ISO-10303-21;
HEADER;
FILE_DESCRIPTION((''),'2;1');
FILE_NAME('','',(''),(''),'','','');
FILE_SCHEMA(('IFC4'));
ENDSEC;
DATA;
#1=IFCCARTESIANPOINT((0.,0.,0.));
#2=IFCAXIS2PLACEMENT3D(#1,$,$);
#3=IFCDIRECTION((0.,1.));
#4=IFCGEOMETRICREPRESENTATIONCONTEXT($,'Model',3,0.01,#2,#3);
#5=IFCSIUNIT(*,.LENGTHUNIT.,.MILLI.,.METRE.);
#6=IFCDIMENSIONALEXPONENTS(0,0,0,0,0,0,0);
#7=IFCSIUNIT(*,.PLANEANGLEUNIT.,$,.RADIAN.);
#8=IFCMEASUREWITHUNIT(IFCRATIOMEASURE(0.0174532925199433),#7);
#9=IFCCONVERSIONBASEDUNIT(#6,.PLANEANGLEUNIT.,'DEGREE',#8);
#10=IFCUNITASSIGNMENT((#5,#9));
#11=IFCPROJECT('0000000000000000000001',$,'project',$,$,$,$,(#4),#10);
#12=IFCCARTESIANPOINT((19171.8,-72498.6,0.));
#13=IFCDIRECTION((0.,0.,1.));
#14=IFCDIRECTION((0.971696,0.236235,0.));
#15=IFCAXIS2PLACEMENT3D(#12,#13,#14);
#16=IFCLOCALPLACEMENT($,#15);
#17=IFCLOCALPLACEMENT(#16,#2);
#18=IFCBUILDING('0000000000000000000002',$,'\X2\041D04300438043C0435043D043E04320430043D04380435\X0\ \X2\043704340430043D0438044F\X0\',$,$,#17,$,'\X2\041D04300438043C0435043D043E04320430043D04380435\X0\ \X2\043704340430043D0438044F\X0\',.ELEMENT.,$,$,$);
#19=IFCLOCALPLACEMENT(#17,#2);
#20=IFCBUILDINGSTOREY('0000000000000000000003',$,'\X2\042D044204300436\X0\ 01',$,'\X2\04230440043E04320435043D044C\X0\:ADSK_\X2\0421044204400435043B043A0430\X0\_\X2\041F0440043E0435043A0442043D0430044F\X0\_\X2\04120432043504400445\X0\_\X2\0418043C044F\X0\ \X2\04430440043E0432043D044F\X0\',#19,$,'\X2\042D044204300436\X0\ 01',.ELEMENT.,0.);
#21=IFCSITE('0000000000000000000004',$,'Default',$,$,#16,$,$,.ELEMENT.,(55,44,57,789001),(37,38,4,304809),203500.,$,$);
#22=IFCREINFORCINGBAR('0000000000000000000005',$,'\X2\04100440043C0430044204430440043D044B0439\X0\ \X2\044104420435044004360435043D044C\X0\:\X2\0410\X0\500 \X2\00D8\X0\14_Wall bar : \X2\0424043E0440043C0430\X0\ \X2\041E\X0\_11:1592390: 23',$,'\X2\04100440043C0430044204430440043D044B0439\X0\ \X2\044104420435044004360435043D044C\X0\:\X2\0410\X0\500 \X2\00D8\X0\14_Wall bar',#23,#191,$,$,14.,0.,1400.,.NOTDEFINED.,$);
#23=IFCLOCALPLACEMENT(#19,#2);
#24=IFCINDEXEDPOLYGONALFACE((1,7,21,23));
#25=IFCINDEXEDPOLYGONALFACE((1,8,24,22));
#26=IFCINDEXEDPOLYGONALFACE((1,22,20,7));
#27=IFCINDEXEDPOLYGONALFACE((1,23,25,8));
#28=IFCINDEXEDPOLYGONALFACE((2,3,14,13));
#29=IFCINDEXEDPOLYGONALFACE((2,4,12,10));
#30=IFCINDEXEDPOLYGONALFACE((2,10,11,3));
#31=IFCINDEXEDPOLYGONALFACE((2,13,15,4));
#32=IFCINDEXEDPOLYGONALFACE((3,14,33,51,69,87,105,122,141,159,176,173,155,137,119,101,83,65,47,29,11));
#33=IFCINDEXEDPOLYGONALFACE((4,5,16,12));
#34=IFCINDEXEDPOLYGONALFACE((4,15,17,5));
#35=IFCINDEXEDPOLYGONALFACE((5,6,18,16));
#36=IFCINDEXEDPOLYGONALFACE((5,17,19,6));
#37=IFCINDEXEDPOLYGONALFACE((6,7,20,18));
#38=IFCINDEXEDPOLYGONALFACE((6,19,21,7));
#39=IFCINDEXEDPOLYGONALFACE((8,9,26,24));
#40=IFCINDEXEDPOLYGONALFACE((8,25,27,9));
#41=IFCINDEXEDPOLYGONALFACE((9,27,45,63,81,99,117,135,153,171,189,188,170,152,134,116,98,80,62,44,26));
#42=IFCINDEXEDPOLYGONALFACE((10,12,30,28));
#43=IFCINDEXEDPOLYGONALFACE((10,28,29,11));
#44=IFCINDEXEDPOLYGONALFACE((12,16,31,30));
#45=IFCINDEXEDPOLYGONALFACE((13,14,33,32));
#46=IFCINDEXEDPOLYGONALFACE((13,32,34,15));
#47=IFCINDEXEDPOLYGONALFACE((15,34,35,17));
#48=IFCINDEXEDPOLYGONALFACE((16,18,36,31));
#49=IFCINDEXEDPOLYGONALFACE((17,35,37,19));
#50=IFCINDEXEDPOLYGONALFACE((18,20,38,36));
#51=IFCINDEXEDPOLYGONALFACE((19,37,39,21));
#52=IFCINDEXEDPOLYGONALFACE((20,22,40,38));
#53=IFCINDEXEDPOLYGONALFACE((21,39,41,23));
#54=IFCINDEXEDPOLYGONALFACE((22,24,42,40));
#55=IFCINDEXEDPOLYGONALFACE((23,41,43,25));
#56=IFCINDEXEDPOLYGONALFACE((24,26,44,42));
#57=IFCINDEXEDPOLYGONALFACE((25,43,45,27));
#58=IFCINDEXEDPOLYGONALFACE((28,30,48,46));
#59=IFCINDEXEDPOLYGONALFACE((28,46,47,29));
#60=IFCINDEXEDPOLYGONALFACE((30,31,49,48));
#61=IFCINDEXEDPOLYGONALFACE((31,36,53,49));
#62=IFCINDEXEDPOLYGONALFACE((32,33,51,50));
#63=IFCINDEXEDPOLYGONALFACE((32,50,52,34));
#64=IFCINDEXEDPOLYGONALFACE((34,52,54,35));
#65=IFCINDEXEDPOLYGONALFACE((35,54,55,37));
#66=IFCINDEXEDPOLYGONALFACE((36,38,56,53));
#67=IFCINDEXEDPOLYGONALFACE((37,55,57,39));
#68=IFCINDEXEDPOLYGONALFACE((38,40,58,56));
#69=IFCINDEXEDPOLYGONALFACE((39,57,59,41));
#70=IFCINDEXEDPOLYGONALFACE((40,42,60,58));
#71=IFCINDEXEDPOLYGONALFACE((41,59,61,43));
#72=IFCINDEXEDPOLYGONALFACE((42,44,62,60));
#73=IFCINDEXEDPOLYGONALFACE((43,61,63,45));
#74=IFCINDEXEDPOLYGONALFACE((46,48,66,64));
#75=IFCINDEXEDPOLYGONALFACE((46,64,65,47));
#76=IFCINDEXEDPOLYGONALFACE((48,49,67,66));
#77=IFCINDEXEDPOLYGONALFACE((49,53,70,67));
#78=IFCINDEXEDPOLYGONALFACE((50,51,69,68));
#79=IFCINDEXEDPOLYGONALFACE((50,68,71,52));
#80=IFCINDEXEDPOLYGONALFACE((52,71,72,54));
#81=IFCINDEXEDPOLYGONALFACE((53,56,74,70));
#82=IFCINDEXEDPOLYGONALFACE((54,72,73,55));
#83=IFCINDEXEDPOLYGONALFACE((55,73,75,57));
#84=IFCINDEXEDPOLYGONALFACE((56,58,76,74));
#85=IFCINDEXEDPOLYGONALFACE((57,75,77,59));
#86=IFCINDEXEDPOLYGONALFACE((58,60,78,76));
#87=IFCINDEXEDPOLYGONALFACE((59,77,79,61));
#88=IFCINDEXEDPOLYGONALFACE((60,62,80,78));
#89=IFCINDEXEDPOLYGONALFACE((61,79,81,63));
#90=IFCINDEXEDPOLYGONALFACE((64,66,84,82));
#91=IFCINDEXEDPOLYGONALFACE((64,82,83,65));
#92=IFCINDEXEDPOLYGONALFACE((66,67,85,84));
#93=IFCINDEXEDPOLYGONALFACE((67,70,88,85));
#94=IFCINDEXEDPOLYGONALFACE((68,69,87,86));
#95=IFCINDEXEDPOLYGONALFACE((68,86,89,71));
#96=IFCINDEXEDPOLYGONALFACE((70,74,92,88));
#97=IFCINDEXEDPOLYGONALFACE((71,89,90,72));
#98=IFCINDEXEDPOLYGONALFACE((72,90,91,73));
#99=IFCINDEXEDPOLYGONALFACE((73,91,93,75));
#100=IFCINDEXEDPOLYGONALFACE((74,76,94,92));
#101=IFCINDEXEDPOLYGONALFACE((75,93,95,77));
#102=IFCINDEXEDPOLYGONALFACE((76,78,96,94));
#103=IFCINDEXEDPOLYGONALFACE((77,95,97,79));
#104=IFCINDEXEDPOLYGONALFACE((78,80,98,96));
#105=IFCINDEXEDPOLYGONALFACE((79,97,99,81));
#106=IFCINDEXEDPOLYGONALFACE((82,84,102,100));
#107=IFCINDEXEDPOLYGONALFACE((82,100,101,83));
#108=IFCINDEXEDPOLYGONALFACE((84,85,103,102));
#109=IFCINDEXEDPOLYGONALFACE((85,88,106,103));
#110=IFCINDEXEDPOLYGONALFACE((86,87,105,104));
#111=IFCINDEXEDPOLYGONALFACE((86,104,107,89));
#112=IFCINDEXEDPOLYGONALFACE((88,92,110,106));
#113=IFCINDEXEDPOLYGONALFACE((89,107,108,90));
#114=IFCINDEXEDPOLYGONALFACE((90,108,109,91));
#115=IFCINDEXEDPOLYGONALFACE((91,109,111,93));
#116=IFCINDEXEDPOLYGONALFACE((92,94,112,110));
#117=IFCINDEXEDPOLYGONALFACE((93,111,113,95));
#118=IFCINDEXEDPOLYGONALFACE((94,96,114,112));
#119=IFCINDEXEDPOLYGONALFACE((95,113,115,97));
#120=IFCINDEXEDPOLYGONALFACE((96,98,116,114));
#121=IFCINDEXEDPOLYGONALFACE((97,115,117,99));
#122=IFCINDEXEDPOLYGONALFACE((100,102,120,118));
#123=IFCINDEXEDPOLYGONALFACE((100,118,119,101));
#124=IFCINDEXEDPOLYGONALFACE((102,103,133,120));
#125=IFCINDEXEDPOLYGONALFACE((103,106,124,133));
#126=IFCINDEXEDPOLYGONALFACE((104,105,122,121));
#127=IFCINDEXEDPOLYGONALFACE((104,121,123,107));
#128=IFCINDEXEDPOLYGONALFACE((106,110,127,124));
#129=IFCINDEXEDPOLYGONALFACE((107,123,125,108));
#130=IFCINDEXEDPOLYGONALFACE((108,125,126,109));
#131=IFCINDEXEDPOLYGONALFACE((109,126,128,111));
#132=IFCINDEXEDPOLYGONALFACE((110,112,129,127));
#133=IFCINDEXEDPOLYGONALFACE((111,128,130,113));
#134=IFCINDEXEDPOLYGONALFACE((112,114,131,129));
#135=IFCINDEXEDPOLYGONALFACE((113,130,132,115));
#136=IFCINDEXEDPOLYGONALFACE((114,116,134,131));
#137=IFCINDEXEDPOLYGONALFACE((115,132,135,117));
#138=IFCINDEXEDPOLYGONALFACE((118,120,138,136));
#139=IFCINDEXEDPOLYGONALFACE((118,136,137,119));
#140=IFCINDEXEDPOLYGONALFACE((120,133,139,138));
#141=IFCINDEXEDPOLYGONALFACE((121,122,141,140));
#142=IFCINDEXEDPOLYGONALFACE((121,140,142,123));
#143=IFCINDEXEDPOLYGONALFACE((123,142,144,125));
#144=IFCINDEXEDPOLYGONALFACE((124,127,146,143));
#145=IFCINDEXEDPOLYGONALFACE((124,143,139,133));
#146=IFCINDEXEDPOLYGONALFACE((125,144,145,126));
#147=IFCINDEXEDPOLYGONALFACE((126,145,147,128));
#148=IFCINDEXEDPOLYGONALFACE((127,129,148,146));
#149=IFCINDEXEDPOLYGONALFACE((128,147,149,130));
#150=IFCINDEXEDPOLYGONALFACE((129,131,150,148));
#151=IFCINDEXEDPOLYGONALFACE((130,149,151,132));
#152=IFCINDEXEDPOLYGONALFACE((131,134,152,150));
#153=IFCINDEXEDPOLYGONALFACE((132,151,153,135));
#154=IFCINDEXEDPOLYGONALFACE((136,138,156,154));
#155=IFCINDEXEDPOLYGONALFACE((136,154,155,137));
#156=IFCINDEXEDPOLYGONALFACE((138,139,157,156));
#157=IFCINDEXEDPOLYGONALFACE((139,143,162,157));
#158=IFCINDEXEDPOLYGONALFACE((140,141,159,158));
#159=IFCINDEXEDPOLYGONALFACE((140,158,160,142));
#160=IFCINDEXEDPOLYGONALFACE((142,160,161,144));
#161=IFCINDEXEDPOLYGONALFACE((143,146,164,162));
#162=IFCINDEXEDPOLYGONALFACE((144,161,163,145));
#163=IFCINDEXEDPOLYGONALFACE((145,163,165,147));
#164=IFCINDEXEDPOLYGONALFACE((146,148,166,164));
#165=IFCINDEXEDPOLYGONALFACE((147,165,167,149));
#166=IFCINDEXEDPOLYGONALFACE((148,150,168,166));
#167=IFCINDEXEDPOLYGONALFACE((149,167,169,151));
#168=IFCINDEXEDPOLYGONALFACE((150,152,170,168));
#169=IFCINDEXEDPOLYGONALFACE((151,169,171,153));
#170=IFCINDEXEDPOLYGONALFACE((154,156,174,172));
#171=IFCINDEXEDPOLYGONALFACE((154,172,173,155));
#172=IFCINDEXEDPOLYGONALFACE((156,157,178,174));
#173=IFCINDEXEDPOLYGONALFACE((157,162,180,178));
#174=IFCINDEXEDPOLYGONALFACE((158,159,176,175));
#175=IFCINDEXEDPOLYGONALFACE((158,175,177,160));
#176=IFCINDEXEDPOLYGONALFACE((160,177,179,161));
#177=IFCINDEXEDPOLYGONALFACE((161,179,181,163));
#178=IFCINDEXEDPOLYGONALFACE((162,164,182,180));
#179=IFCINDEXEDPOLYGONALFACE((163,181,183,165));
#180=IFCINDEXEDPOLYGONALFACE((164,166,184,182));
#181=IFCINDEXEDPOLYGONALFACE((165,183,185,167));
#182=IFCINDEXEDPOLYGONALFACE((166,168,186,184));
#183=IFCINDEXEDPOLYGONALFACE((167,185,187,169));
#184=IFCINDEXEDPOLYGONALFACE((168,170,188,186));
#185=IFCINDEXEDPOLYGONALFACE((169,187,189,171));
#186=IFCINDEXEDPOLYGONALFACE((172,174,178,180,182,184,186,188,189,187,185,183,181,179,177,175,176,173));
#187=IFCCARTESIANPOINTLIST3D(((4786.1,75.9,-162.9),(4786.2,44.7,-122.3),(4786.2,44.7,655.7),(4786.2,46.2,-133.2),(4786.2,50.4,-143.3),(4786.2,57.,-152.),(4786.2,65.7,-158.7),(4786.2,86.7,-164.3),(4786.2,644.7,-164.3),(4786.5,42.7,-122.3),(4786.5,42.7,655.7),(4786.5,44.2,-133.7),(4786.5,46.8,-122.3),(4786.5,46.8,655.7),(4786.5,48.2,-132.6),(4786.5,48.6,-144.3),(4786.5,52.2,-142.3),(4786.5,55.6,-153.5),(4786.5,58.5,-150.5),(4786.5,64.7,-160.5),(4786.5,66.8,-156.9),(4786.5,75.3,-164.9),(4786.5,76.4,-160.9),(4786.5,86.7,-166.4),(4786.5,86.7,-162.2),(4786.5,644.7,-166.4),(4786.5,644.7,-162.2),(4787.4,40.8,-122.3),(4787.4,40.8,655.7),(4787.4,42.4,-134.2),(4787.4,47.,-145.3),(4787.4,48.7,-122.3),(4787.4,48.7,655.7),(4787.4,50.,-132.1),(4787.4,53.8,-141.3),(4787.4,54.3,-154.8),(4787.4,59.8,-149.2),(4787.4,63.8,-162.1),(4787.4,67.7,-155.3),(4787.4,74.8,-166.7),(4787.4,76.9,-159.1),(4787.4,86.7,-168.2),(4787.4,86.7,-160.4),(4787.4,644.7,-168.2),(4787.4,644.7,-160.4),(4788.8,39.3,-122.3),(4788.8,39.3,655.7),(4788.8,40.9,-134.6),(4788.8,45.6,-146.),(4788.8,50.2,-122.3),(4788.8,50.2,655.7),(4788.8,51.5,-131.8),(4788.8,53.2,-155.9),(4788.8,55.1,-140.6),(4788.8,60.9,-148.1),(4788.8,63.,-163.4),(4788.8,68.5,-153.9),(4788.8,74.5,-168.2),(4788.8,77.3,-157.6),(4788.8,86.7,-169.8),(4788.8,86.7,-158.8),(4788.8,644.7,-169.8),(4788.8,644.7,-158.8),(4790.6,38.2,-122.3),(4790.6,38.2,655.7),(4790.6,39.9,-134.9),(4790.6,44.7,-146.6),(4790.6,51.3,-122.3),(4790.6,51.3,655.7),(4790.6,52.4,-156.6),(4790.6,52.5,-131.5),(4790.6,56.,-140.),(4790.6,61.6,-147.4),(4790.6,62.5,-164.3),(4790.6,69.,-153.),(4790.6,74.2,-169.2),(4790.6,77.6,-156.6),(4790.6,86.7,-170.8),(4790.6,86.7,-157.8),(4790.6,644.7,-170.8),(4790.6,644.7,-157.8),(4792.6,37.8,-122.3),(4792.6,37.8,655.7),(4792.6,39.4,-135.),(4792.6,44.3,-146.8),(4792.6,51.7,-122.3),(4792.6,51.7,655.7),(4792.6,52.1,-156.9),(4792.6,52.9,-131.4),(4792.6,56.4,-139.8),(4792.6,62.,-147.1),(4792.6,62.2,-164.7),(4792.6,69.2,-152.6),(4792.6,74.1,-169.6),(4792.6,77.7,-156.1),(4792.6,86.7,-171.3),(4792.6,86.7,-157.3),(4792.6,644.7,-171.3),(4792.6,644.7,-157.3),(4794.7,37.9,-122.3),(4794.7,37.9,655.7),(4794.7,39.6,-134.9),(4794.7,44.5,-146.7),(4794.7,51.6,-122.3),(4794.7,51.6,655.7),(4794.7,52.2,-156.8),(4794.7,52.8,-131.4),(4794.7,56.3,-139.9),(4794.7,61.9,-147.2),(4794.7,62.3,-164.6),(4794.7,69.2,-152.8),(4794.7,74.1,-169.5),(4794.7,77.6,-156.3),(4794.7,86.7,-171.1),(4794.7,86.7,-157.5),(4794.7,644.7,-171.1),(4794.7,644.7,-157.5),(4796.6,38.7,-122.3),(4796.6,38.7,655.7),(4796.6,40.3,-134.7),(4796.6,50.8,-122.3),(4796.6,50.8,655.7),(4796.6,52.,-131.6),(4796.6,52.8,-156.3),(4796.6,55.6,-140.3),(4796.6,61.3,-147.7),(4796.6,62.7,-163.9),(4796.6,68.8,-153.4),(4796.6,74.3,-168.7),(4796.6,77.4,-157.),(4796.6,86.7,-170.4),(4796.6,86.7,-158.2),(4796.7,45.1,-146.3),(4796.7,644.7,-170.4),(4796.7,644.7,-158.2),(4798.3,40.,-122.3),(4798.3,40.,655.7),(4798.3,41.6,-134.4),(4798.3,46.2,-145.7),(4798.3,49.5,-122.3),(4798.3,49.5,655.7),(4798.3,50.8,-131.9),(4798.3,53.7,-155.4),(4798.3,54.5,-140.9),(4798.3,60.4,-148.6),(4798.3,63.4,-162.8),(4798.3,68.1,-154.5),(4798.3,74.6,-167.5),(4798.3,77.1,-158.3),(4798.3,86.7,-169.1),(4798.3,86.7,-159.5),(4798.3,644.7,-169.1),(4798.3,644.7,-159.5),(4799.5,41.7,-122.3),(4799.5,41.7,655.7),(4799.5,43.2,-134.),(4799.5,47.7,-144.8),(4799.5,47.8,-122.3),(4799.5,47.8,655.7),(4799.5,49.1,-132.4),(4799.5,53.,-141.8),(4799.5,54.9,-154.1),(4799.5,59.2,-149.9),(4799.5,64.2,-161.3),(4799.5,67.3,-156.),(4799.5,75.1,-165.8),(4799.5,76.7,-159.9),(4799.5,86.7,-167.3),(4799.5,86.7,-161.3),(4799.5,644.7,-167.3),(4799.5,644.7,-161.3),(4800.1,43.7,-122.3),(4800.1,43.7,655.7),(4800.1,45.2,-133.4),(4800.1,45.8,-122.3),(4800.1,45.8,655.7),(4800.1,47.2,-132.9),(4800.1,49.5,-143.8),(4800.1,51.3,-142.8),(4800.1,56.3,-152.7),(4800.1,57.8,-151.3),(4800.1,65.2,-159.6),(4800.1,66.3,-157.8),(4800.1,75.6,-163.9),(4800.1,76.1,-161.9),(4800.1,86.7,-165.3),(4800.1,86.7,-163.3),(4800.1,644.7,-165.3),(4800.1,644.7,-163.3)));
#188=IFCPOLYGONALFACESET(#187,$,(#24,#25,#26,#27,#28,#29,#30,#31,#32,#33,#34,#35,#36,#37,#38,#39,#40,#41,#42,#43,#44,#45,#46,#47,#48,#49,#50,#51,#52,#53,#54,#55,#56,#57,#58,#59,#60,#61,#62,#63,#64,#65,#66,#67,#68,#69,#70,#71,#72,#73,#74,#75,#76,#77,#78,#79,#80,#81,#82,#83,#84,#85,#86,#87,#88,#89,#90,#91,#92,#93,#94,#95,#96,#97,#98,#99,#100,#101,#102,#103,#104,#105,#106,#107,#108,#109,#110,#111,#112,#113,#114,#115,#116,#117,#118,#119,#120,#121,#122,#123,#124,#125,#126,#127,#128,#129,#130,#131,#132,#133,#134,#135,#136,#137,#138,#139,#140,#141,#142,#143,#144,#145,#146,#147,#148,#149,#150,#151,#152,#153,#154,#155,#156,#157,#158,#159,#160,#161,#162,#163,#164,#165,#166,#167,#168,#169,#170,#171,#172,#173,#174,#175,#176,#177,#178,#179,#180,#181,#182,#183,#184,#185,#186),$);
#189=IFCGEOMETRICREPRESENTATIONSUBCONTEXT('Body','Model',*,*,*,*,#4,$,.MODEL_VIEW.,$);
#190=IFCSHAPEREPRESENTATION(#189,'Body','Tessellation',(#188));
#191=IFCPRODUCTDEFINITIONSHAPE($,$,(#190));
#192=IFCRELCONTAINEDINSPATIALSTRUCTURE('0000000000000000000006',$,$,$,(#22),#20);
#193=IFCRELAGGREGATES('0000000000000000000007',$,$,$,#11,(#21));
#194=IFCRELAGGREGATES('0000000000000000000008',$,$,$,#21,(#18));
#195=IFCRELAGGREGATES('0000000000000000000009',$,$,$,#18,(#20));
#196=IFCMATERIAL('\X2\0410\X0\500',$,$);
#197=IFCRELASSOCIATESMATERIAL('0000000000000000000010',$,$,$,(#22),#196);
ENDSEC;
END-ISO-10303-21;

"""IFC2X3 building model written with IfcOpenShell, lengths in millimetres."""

from ifc_helpers import new_model, entity, si_unit, converted_unit, direction, frame, origin, place, context, subcontext, project, spatial, material, element, save


model = new_model("IFC2X3")

# Units and contexts
model_context = context("Model", 3, precision=0.01, world=origin(), true_north=direction((0.0, 1.0)))
body_context = subcontext(model_context, "Body", "Model", "MODEL_VIEW")
ifc_project = project(units=[si_unit("LENGTHUNIT", "METRE", prefix="MILLI"), converted_unit("PLANEANGLEUNIT", "DEGREE", entity("IfcRatioMeasure", 0.0174532925199433), si_unit("PLANEANGLEUNIT", "RADIAN"), dimensions=[0, 0, 0, 0, 0, 0, 0])], contexts=[model_context])

# Site, building, storey
site_placement = place(None, frame((19171.8, -72498.6, 0.0), z_axis=(0.0, 0.0, 1.0), x_axis=(0.971696, 0.236235, 0.0)))
site = spatial("IfcSite", under=ifc_project, at=site_placement, Name="Default", CompositionType="ELEMENT", RefLatitude=(55, 44, 57, 789001), RefLongitude=(37, 38, 4, 304809), RefElevation=203500.0)
building_placement = place(site_placement, origin())
building = spatial("IfcBuilding", under=site, at=building_placement, Name="Наименование здания", LongName="Наименование здания", CompositionType="ELEMENT")
storey_placement = place(building_placement, origin())
storey = spatial("IfcBuildingStorey", under=building, at=storey_placement, Name="Этаж 01", ObjectType="Уровень:ADSK_Стрелка_Проектная_Вверх_Имя уровня", LongName="Этаж 01", CompositionType="ELEMENT", Elevation=0.0)

# Reinforcing bar
ifc_material = material(Name="А500")
placement = place(storey_placement, origin())
element("IfcReinforcingBar", 1, at=placement, inside=storey, material=ifc_material, Name="Арматурный стержень:А500 Ø14_Wall bar : Форма О_11:1592390: 23", ObjectType="Арматурный стержень:А500 Ø14_Wall bar", BarLength=1400.0, BarRole="NOTDEFINED", CrossSectionArea=0.0, NominalDiameter=14.0, context=body_context, shape_type="AdvancedSweptSolid", body=[
    entity("IfcSweptDiskSolid", entity("IfcCompositeCurve", [entity("IfcCompositeCurveSegment", "CONTINUOUS", True, entity("IfcPolyline", [entity("IfcCartesianPoint", [4793.1, 44.7, 655.7]), entity("IfcCartesianPoint", [4793.1, 44.7, -122.3])])), entity("IfcCompositeCurveSegment", "CONTINUOUS", True, entity("IfcTrimmedCurve", entity("IfcCircle", entity("IfcAxis2Placement3D", entity("IfcCartesianPoint", [4793.1, 86.7, -122.3]), entity("IfcDirection", [1.0, 0.0, 0.0]), entity("IfcDirection", [0.0, 0.0, -1.0])), 42.0), [entity("IfcParameterValue", 270.0)], [entity("IfcParameterValue", 360.0)], True, "PARAMETER")), entity("IfcCompositeCurveSegment", "CONTINUOUS", True, entity("IfcPolyline", [entity("IfcCartesianPoint", [4793.1, 86.7, -164.3]), entity("IfcCartesianPoint", [4793.1, 644.7, -164.3])]))], False), 7.0, None, 0.0, 92.0),
])

save(model, "model.ifc")
